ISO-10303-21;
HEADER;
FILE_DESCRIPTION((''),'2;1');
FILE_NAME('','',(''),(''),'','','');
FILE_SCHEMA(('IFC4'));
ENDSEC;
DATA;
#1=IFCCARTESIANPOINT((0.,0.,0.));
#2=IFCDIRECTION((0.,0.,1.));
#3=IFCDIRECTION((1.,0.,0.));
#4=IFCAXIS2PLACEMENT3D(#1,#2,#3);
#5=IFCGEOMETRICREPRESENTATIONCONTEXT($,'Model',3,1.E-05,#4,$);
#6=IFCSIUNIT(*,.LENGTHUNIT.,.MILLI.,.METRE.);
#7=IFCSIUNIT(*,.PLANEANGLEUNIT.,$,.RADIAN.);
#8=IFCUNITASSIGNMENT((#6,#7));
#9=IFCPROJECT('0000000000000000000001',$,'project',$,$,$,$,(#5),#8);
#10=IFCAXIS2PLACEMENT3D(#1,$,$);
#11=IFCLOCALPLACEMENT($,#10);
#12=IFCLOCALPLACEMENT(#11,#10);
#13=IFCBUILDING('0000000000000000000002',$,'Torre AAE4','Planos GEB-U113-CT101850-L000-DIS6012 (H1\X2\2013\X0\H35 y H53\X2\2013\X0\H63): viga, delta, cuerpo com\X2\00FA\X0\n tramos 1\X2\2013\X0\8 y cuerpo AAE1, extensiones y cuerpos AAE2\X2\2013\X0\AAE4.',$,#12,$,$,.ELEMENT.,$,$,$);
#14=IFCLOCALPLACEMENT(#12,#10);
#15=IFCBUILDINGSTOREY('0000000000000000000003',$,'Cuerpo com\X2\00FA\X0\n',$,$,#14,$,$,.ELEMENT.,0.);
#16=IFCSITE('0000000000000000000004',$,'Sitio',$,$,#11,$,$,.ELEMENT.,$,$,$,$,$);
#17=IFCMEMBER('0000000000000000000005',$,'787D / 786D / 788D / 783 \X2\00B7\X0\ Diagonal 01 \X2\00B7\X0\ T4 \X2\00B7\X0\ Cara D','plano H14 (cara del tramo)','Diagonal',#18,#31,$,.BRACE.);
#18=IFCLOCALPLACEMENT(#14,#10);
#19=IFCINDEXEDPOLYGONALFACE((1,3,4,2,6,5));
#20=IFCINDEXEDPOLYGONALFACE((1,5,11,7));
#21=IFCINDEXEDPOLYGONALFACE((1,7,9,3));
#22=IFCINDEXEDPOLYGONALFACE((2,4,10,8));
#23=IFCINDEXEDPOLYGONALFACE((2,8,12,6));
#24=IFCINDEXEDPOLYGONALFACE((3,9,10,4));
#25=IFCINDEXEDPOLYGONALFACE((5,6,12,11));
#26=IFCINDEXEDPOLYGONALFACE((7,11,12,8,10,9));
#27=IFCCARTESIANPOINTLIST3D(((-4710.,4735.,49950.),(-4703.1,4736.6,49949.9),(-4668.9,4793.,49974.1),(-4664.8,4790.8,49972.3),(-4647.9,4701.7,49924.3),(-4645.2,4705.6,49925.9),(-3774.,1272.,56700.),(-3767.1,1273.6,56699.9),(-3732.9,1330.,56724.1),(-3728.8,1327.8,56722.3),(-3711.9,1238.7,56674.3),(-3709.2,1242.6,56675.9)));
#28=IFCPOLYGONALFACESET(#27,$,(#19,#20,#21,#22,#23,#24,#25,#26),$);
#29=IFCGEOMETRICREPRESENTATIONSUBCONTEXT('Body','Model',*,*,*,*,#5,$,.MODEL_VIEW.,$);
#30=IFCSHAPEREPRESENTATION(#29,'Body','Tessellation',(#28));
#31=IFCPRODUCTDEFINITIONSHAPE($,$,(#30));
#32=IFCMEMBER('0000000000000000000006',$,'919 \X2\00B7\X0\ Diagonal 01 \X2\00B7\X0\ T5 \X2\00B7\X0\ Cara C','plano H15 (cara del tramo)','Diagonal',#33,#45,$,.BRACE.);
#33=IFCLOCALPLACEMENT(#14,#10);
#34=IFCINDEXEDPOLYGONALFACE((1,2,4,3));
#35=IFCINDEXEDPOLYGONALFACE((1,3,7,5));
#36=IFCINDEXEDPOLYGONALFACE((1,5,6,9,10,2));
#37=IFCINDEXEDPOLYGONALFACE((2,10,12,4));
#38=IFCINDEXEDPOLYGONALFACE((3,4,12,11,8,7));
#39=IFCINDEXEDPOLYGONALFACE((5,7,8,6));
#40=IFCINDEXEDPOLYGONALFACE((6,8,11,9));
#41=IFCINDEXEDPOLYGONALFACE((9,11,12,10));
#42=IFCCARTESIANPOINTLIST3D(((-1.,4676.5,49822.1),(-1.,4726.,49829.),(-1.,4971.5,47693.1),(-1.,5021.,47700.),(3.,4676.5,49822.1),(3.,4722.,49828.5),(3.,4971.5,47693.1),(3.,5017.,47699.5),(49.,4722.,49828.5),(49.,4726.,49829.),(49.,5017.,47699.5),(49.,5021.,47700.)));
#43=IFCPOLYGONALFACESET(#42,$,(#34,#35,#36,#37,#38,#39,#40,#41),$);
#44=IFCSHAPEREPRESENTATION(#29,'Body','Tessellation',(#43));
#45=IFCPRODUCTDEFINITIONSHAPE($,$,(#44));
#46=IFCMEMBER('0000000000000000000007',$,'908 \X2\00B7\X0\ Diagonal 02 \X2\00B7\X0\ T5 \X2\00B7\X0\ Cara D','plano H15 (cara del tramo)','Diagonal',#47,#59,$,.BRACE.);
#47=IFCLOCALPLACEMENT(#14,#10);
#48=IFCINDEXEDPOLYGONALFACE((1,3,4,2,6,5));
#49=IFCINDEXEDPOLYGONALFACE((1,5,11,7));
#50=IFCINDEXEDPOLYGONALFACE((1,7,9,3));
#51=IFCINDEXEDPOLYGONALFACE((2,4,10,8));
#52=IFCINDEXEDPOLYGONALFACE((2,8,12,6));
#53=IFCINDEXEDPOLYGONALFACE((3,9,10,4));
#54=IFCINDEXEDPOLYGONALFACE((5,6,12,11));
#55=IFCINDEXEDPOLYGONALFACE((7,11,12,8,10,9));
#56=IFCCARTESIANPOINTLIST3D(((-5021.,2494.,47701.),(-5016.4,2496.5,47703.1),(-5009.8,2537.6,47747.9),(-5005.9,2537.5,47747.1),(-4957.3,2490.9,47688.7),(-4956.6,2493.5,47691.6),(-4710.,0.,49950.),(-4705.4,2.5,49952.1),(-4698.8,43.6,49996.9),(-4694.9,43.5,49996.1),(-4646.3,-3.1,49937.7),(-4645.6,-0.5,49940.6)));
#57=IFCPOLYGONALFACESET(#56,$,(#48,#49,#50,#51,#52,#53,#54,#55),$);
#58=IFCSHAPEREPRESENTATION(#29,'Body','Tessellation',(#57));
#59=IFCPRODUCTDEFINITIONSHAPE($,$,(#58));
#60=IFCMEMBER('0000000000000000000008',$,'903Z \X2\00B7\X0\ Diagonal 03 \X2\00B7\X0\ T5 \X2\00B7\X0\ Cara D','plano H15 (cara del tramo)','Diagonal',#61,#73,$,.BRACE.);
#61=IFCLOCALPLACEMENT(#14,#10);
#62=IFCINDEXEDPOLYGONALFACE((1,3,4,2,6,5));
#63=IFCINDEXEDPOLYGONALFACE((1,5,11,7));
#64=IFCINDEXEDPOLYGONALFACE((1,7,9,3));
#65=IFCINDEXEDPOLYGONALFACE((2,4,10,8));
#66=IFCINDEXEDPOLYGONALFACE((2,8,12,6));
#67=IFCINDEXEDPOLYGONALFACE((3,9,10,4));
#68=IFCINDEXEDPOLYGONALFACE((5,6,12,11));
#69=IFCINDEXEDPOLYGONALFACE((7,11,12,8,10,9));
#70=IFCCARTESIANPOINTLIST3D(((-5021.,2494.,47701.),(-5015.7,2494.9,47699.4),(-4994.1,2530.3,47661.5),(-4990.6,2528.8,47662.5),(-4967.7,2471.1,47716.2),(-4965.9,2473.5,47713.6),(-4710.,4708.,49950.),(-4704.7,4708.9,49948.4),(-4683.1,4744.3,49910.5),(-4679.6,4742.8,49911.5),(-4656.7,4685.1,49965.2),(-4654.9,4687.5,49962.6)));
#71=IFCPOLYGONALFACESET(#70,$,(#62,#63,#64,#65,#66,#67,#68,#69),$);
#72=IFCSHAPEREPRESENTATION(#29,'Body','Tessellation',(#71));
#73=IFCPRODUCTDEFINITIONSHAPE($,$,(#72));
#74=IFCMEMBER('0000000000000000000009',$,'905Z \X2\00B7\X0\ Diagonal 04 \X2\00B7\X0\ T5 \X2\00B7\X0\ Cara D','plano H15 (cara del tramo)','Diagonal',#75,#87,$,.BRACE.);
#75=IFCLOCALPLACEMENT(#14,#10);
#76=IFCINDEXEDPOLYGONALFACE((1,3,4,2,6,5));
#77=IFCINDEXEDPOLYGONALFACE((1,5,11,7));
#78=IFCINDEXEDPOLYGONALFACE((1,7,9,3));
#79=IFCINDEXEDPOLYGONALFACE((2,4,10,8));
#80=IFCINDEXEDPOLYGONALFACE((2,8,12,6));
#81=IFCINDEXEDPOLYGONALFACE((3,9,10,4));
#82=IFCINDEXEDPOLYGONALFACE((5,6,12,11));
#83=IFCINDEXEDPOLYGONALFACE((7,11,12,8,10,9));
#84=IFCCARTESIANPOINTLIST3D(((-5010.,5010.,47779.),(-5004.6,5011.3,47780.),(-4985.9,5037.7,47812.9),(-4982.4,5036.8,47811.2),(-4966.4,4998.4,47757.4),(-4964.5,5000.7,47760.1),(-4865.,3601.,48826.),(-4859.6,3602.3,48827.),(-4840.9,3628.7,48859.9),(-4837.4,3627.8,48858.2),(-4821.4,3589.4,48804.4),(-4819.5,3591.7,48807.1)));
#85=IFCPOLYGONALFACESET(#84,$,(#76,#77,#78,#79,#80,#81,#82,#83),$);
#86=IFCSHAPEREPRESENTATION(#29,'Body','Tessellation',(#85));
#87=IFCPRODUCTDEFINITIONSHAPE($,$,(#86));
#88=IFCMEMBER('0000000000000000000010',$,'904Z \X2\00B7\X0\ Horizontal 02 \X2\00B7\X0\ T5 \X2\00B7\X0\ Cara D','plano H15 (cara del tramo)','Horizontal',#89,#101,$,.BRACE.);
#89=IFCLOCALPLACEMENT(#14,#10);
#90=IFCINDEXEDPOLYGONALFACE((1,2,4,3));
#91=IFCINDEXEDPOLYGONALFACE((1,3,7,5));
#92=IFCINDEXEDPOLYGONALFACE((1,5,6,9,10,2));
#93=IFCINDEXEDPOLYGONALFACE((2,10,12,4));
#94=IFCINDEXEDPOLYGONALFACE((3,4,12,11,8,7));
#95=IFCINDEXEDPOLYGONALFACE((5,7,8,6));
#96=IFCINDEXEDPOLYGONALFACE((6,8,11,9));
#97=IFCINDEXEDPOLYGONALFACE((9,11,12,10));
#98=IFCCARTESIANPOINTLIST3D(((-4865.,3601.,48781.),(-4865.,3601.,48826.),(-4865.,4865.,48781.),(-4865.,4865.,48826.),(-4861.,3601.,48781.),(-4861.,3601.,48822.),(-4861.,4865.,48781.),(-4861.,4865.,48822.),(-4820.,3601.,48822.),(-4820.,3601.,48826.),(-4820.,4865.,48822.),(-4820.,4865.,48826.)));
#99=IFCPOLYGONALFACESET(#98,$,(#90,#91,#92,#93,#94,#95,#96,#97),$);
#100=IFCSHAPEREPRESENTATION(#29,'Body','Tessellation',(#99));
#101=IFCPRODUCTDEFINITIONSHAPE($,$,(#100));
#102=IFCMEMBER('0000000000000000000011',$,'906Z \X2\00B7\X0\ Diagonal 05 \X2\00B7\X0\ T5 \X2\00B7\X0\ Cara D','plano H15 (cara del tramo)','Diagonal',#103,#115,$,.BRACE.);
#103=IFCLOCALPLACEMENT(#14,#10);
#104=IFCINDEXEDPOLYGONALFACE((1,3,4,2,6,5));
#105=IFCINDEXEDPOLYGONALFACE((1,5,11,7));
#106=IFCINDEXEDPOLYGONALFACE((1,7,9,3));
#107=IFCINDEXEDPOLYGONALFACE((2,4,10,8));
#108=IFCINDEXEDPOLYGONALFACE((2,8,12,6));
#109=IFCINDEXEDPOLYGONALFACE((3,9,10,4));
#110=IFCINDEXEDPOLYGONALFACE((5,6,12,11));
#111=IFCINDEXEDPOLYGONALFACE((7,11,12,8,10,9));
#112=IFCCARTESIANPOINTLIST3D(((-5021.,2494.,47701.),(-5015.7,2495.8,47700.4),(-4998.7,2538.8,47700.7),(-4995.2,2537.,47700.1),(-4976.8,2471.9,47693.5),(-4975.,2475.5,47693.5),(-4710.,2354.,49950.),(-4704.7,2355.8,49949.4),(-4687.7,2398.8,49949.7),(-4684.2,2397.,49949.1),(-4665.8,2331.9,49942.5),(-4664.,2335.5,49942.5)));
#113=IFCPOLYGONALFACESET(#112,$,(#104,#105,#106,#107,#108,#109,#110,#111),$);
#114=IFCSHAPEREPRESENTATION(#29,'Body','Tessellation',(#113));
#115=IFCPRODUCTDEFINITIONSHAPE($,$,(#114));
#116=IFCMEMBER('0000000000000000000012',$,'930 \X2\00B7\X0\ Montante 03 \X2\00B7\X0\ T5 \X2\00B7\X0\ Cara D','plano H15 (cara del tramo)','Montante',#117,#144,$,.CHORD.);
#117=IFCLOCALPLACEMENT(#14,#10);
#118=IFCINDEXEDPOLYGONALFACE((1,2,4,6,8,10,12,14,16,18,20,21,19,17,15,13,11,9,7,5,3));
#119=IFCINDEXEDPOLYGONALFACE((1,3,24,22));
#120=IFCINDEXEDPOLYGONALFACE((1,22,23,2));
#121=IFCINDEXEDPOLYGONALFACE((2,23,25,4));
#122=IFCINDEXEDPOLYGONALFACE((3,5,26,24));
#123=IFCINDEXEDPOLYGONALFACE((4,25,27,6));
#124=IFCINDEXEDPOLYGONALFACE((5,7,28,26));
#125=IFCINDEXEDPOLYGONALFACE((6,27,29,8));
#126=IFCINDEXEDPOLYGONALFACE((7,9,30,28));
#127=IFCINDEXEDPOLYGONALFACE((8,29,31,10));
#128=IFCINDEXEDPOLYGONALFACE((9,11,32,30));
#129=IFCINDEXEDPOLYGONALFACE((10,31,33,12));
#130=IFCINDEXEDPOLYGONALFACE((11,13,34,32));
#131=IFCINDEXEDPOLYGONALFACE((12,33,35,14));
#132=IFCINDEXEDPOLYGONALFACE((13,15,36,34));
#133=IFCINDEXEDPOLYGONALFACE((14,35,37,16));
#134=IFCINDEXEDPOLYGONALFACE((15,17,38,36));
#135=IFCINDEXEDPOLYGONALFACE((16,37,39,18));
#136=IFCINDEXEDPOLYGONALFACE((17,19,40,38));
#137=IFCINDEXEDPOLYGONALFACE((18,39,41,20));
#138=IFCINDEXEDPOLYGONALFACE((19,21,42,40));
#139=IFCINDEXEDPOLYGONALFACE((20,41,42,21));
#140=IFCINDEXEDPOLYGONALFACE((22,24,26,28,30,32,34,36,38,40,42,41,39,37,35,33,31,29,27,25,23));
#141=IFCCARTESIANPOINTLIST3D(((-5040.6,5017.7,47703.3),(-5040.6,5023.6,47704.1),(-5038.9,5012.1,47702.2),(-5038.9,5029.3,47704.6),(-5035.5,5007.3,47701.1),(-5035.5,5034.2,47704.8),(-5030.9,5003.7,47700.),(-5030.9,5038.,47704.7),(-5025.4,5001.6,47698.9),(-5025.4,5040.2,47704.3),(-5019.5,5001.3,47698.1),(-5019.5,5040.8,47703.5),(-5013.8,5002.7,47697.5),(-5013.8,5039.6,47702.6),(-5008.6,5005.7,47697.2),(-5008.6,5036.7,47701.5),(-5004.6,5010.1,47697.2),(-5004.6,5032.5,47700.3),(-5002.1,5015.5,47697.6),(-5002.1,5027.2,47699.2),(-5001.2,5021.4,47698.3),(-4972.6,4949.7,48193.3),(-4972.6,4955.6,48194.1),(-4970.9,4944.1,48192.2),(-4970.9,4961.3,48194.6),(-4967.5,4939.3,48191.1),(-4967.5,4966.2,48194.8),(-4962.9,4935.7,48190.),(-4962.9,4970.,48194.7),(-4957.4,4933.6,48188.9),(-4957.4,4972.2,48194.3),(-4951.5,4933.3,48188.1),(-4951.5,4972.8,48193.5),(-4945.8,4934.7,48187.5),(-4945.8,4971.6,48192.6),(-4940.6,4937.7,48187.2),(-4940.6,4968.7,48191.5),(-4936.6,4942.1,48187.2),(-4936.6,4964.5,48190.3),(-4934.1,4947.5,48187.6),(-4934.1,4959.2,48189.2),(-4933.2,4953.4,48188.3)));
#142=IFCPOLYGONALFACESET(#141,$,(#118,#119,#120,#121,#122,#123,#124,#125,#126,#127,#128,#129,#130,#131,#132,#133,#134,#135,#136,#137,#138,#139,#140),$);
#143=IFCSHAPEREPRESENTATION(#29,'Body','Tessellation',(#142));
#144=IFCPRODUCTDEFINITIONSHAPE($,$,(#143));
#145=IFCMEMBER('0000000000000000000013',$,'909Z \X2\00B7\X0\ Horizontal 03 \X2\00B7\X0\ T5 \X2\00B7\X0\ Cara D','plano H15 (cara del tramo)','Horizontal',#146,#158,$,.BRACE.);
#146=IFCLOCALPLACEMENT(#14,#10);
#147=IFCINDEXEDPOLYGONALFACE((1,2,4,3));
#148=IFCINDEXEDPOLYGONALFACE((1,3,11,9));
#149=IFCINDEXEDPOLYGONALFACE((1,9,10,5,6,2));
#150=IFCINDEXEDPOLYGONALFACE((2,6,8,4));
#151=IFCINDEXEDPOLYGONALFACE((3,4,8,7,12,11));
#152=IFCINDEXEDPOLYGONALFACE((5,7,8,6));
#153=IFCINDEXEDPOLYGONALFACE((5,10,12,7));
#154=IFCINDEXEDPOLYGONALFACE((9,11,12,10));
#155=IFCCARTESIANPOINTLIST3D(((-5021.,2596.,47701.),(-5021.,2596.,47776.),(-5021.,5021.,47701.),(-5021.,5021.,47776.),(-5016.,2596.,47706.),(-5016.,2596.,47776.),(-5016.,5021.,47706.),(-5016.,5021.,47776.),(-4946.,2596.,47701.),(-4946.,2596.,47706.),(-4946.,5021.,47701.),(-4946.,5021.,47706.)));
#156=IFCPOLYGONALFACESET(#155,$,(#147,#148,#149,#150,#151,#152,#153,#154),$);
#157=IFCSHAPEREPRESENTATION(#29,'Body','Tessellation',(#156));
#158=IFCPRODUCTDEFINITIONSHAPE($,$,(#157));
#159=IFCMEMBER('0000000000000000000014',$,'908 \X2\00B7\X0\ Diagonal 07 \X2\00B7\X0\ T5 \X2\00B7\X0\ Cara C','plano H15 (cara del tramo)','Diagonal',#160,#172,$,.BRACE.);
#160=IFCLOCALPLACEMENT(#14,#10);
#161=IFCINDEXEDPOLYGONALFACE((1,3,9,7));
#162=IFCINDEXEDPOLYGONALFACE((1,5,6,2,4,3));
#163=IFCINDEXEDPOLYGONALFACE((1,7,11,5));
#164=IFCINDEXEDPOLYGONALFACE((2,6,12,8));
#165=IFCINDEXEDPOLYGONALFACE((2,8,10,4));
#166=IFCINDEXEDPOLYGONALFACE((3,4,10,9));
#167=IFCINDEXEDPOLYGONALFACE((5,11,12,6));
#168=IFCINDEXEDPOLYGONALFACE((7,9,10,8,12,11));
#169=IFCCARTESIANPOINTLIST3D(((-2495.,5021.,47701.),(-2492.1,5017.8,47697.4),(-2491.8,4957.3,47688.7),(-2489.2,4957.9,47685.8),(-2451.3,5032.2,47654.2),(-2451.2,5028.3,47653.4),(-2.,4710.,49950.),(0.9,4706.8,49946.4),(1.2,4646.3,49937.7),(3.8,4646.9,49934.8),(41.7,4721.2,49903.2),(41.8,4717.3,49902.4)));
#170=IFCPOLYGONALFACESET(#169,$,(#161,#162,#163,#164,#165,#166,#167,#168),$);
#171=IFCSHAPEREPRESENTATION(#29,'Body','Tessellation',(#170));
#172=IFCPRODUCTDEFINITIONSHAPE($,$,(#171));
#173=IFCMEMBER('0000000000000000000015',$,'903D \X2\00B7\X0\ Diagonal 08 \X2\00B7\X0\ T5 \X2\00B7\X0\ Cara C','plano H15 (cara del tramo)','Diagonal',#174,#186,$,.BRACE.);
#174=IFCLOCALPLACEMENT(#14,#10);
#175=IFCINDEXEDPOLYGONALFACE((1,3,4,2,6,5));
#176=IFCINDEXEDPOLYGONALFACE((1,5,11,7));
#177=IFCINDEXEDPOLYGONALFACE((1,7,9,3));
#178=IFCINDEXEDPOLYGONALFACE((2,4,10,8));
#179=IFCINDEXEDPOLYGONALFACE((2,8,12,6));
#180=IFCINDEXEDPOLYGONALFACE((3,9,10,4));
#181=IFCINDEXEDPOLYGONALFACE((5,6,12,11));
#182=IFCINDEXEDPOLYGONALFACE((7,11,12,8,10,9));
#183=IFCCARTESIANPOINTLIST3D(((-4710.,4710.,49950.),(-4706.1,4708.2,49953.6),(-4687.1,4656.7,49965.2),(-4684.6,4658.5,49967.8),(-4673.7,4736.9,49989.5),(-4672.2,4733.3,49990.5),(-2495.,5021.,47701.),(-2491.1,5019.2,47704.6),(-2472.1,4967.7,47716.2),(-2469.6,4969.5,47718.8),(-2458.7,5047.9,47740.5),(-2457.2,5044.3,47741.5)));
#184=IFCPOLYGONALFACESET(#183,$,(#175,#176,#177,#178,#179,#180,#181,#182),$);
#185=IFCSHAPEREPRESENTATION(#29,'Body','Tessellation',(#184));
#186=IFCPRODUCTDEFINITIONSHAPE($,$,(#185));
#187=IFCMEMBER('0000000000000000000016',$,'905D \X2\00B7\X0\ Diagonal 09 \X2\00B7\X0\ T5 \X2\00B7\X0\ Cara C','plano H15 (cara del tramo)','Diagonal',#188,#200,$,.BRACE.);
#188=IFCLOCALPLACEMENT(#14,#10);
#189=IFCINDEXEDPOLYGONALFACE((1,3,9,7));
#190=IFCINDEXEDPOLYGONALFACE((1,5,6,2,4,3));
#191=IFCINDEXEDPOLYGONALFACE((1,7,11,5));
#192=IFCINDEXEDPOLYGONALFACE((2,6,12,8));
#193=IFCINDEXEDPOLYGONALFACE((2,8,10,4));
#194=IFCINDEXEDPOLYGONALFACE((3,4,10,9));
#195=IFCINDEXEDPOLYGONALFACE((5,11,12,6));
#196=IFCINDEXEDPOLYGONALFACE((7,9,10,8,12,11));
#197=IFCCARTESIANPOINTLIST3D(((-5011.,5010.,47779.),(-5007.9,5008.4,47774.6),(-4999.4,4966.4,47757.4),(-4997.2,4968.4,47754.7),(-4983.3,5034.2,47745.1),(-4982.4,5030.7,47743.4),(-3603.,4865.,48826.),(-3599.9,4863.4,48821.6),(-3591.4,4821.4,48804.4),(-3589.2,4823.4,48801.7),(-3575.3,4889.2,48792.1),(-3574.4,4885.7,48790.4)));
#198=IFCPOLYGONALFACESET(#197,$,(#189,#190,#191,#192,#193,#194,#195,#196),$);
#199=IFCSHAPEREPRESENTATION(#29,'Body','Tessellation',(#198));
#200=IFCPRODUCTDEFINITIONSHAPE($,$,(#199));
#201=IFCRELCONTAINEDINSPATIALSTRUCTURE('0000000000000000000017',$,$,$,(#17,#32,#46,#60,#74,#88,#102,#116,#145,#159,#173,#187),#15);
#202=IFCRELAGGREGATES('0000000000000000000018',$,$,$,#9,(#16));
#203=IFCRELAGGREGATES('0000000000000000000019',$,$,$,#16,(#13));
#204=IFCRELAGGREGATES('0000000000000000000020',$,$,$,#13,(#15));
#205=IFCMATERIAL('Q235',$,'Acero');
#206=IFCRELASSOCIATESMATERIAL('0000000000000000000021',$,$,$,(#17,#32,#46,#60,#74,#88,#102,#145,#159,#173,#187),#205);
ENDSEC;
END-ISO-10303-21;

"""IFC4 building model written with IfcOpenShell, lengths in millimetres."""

from ifc_helpers import new_model, si_unit, frame, frame_2d, origin, origin_with_axes, place, context, subcontext, project, spatial, circle, l_section, extrude, material, element, save


model = new_model("IFC4")

# Units and contexts
model_context = context("Model", 3, precision=1e-05, world=origin_with_axes())
body_context = subcontext(model_context, "Body", "Model", "MODEL_VIEW")
ifc_project = project(units=[si_unit("LENGTHUNIT", "METRE", prefix="MILLI"), si_unit("PLANEANGLEUNIT", "RADIAN")], contexts=[model_context])

# Site, building, storey
site_placement = place(None, origin())
site = spatial("IfcSite", under=ifc_project, at=site_placement, Name="Sitio", CompositionType="ELEMENT")
building_placement = place(site_placement, origin())
building = spatial("IfcBuilding", under=site, at=building_placement, Name="Torre AAE4", Description="Planos GEB-U113-CT101850-L000-DIS6012 (H1–H35 y H53–H63): viga, delta, cuerpo común tramos 1–8 y cuerpo AAE1, extensiones y cuerpos AAE2–AAE4.", CompositionType="ELEMENT")
storey_placement = place(building_placement, origin())
storey = spatial("IfcBuildingStorey", under=building, at=storey_placement, Name="Cuerpo común", CompositionType="ELEMENT", Elevation=0.0)

# Members
ifc_material_1 = material(Name="Q235", Category="Acero")
member_1_placement = place(storey_placement, frame((-4710.0, 4735.0, 49950.0), z_axis=(0.122449, -0.453034, 0.883044), x_axis=(0.827907, -0.444053, -0.342619)))
element("IfcMember", 1, at=member_1_placement, inside=storey, material=ifc_material_1, Name="787D / 786D / 788D / 783 · Diagonal 01 · T4 · Cara D", Description="plano H14 (cara del tramo)", ObjectType="Diagonal", PredefinedType="BRACE", context=body_context, shape_type="SweptSolid", body=[
    extrude(l_section(Depth=75.0, Width=75.0, Thickness=5.0, at=frame_2d((37.5, 37.5))), None, (0.0, 0.0, 1.0), 7644.0),
])
member_2_placement = place(storey_placement, frame((-1.0, 5021.0, 47700.0), z_axis=(0.0, -0.137251, 0.990536), x_axis=(0.000207, -0.990536, -0.137251)))
element("IfcMember", 2, at=member_2_placement, inside=storey, material=ifc_material_1, Name="919 · Diagonal 01 · T5 · Cara C", Description="plano H15 (cara del tramo)", ObjectType="Diagonal", PredefinedType="BRACE", context=body_context, shape_type="SweptSolid", body=[
    extrude(l_section(Depth=50.0, Width=50.0, Thickness=4.0, at=frame_2d((25.0, 25.0))), None, (0.0, 0.0, 1.0), 2149.3),
])
member_3_placement = place(storey_placement, frame((-5021.0, 2494.0, 47701.0), z_axis=(0.092212, -0.739478, 0.666835), x_axis=(0.980756, -0.048288, -0.189171)))
element("IfcMember", 3, at=member_3_placement, inside=storey, material=ifc_material_1, Name="908 · Diagonal 02 · T5 · Cara D", Description="plano H15 (cara del tramo)", ObjectType="Diagonal", PredefinedType="BRACE", context=body_context, shape_type="SweptSolid", body=[
    extrude(l_section(Depth=65.0, Width=65.0, Thickness=4.0, at=frame_2d((32.5, 32.5))), None, (0.0, 0.0, 1.0), 3372.6),
])
member_4_placement = place(storey_placement, frame((-5021.0, 2494.0, 47701.0), z_axis=(0.09807, 0.698158, 0.709195), x_axis=(0.888624, -0.382258, 0.253427)))
element("IfcMember", 4, at=member_4_placement, inside=storey, material=ifc_material_1, Name="903Z · Diagonal 03 · T5 · Cara D", Description="plano H15 (cara del tramo)", ObjectType="Diagonal", PredefinedType="BRACE", context=body_context, shape_type="SweptSolid", body=[
    extrude(l_section(Depth=60.0, Width=60.0, Thickness=4.0, at=frame_2d((30.0, 30.0))), None, (0.0, 0.0, 1.0), 3171.2),
])
member_5_placement = place(storey_placement, frame((-5010.0, 5010.0, 47779.0), z_axis=(0.082321, -0.799934, 0.594415), x_axis=(0.871806, -0.231191, -0.431862)))
element("IfcMember", 5, at=member_5_placement, inside=storey, material=ifc_material_1, Name="905Z · Diagonal 04 · T5 · Cara D", Description="plano H15 (cara del tramo)", ObjectType="Diagonal", PredefinedType="BRACE", context=body_context, shape_type="SweptSolid", body=[
    extrude(l_section(Depth=50.0, Width=50.0, Thickness=4.0, at=frame_2d((25.0, 25.0))), None, (0.0, 0.0, 1.0), 1761.4),
])
member_6_placement = place(storey_placement, frame((-4865.0, 3601.0, 48826.0), z_axis=(0.0, 1.0, 0.0), x_axis=(1.0, 0.0, 0.0)))
element("IfcMember", 6, at=member_6_placement, inside=storey, material=ifc_material_1, Name="904Z · Horizontal 02 · T5 · Cara D", Description="plano H15 (cara del tramo)", ObjectType="Horizontal", PredefinedType="BRACE", context=body_context, shape_type="SweptSolid", body=[
    extrude(l_section(Depth=45.0, Width=45.0, Thickness=4.0, at=frame_2d((22.5, 22.5))), None, (0.0, 0.0, 1.0), 1264.0),
])
member_7_placement = place(storey_placement, frame((-5021.0, 2494.0, 47701.0), z_axis=(0.136721, -0.061546, 0.988696), x_axis=(0.884571, -0.44169, -0.149817)))
element("IfcMember", 7, at=member_7_placement, inside=storey, material=ifc_material_1, Name="906Z · Diagonal 05 · T5 · Cara D", Description="plano H15 (cara del tramo)", ObjectType="Diagonal", PredefinedType="BRACE", context=body_context, shape_type="SweptSolid", body=[
    extrude(l_section(Depth=50.0, Width=50.0, Thickness=4.0, at=frame_2d((25.0, 25.0))), None, (0.0, 0.0, 1.0), 2274.7),
])
member_8_placement = place(storey_placement, frame((-4953.0, 4953.0, 48191.0), z_axis=(-0.136178, 0.136178, -0.98128), x_axis=(0.990684, 0.018719, -0.134885)))
element("IfcMember", 8, at=member_8_placement, inside=storey, Name="930 · Montante 03 · T5 · Cara D", Description="plano H15 (cara del tramo)", ObjectType="Montante", PredefinedType="CHORD", context=body_context, shape_type="SweptSolid", body=[
    extrude(circle(Radius=20.0), None, (0.0, 0.0, 1.0), 499.3),
])
member_9_placement = place(storey_placement, frame((-5021.0, 5021.0, 47701.0), z_axis=(0.0, -1.0, 0.0), x_axis=(1.0, 0.0, 0.0)))
element("IfcMember", 9, at=member_9_placement, inside=storey, material=ifc_material_1, Name="909Z · Horizontal 03 · T5 · Cara D", Description="plano H15 (cara del tramo)", ObjectType="Horizontal", PredefinedType="BRACE", context=body_context, shape_type="SweptSolid", body=[
    extrude(l_section(Depth=75.0, Width=75.0, Thickness=5.0, at=frame_2d((37.5, 37.5))), None, (0.0, 0.0, 1.0), 2425.0),
])
member_10_placement = place(storey_placement, frame((-2495.0, 5021.0, 47701.0), z_axis=(0.739344, -0.092233, 0.666981), x_axis=(0.048477, -0.980712, -0.189352)))
element("IfcMember", 10, at=member_10_placement, inside=storey, material=ifc_material_1, Name="908 · Diagonal 07 · T5 · Cara C", Description="plano H15 (cara del tramo)", ObjectType="Diagonal", PredefinedType="BRACE", context=body_context, shape_type="SweptSolid", body=[
    extrude(l_section(Depth=65.0, Width=65.0, Thickness=4.0, at=frame_2d((32.5, 32.5))), None, (0.0, 0.0, 1.0), 3371.9),
])
member_11_placement = place(storey_placement, frame((-2495.0, 5021.0, 47701.0), z_axis=(-0.69832, -0.098049, 0.709039), x_axis=(0.382229, -0.888595, 0.253573)))
element("IfcMember", 11, at=member_11_placement, inside=storey, material=ifc_material_1, Name="903D · Diagonal 08 · T5 · Cara C", Description="plano H15 (cara del tramo)", ObjectType="Diagonal", PredefinedType="BRACE", context=body_context, shape_type="SweptSolid", body=[
    extrude(l_section(Depth=60.0, Width=60.0, Thickness=4.0, at=frame_2d((30.0, 30.0))), None, (0.0, 0.0, 1.0), 3171.9),
])
member_12_placement = place(storey_placement, frame((-5011.0, 5010.0, 47779.0), z_axis=(0.799729, -0.082358, 0.594685), x_axis=(0.231509, -0.871631, -0.432045)))
element("IfcMember", 12, at=member_12_placement, inside=storey, material=ifc_material_1, Name="905D · Diagonal 09 · T5 · Cara C", Description="plano H15 (cara del tramo)", ObjectType="Diagonal", PredefinedType="BRACE", context=body_context, shape_type="SweptSolid", body=[
    extrude(l_section(Depth=50.0, Width=50.0, Thickness=4.0, at=frame_2d((25.0, 25.0))), None, (0.0, 0.0, 1.0), 1760.6),
])

save(model, "model.ifc")
